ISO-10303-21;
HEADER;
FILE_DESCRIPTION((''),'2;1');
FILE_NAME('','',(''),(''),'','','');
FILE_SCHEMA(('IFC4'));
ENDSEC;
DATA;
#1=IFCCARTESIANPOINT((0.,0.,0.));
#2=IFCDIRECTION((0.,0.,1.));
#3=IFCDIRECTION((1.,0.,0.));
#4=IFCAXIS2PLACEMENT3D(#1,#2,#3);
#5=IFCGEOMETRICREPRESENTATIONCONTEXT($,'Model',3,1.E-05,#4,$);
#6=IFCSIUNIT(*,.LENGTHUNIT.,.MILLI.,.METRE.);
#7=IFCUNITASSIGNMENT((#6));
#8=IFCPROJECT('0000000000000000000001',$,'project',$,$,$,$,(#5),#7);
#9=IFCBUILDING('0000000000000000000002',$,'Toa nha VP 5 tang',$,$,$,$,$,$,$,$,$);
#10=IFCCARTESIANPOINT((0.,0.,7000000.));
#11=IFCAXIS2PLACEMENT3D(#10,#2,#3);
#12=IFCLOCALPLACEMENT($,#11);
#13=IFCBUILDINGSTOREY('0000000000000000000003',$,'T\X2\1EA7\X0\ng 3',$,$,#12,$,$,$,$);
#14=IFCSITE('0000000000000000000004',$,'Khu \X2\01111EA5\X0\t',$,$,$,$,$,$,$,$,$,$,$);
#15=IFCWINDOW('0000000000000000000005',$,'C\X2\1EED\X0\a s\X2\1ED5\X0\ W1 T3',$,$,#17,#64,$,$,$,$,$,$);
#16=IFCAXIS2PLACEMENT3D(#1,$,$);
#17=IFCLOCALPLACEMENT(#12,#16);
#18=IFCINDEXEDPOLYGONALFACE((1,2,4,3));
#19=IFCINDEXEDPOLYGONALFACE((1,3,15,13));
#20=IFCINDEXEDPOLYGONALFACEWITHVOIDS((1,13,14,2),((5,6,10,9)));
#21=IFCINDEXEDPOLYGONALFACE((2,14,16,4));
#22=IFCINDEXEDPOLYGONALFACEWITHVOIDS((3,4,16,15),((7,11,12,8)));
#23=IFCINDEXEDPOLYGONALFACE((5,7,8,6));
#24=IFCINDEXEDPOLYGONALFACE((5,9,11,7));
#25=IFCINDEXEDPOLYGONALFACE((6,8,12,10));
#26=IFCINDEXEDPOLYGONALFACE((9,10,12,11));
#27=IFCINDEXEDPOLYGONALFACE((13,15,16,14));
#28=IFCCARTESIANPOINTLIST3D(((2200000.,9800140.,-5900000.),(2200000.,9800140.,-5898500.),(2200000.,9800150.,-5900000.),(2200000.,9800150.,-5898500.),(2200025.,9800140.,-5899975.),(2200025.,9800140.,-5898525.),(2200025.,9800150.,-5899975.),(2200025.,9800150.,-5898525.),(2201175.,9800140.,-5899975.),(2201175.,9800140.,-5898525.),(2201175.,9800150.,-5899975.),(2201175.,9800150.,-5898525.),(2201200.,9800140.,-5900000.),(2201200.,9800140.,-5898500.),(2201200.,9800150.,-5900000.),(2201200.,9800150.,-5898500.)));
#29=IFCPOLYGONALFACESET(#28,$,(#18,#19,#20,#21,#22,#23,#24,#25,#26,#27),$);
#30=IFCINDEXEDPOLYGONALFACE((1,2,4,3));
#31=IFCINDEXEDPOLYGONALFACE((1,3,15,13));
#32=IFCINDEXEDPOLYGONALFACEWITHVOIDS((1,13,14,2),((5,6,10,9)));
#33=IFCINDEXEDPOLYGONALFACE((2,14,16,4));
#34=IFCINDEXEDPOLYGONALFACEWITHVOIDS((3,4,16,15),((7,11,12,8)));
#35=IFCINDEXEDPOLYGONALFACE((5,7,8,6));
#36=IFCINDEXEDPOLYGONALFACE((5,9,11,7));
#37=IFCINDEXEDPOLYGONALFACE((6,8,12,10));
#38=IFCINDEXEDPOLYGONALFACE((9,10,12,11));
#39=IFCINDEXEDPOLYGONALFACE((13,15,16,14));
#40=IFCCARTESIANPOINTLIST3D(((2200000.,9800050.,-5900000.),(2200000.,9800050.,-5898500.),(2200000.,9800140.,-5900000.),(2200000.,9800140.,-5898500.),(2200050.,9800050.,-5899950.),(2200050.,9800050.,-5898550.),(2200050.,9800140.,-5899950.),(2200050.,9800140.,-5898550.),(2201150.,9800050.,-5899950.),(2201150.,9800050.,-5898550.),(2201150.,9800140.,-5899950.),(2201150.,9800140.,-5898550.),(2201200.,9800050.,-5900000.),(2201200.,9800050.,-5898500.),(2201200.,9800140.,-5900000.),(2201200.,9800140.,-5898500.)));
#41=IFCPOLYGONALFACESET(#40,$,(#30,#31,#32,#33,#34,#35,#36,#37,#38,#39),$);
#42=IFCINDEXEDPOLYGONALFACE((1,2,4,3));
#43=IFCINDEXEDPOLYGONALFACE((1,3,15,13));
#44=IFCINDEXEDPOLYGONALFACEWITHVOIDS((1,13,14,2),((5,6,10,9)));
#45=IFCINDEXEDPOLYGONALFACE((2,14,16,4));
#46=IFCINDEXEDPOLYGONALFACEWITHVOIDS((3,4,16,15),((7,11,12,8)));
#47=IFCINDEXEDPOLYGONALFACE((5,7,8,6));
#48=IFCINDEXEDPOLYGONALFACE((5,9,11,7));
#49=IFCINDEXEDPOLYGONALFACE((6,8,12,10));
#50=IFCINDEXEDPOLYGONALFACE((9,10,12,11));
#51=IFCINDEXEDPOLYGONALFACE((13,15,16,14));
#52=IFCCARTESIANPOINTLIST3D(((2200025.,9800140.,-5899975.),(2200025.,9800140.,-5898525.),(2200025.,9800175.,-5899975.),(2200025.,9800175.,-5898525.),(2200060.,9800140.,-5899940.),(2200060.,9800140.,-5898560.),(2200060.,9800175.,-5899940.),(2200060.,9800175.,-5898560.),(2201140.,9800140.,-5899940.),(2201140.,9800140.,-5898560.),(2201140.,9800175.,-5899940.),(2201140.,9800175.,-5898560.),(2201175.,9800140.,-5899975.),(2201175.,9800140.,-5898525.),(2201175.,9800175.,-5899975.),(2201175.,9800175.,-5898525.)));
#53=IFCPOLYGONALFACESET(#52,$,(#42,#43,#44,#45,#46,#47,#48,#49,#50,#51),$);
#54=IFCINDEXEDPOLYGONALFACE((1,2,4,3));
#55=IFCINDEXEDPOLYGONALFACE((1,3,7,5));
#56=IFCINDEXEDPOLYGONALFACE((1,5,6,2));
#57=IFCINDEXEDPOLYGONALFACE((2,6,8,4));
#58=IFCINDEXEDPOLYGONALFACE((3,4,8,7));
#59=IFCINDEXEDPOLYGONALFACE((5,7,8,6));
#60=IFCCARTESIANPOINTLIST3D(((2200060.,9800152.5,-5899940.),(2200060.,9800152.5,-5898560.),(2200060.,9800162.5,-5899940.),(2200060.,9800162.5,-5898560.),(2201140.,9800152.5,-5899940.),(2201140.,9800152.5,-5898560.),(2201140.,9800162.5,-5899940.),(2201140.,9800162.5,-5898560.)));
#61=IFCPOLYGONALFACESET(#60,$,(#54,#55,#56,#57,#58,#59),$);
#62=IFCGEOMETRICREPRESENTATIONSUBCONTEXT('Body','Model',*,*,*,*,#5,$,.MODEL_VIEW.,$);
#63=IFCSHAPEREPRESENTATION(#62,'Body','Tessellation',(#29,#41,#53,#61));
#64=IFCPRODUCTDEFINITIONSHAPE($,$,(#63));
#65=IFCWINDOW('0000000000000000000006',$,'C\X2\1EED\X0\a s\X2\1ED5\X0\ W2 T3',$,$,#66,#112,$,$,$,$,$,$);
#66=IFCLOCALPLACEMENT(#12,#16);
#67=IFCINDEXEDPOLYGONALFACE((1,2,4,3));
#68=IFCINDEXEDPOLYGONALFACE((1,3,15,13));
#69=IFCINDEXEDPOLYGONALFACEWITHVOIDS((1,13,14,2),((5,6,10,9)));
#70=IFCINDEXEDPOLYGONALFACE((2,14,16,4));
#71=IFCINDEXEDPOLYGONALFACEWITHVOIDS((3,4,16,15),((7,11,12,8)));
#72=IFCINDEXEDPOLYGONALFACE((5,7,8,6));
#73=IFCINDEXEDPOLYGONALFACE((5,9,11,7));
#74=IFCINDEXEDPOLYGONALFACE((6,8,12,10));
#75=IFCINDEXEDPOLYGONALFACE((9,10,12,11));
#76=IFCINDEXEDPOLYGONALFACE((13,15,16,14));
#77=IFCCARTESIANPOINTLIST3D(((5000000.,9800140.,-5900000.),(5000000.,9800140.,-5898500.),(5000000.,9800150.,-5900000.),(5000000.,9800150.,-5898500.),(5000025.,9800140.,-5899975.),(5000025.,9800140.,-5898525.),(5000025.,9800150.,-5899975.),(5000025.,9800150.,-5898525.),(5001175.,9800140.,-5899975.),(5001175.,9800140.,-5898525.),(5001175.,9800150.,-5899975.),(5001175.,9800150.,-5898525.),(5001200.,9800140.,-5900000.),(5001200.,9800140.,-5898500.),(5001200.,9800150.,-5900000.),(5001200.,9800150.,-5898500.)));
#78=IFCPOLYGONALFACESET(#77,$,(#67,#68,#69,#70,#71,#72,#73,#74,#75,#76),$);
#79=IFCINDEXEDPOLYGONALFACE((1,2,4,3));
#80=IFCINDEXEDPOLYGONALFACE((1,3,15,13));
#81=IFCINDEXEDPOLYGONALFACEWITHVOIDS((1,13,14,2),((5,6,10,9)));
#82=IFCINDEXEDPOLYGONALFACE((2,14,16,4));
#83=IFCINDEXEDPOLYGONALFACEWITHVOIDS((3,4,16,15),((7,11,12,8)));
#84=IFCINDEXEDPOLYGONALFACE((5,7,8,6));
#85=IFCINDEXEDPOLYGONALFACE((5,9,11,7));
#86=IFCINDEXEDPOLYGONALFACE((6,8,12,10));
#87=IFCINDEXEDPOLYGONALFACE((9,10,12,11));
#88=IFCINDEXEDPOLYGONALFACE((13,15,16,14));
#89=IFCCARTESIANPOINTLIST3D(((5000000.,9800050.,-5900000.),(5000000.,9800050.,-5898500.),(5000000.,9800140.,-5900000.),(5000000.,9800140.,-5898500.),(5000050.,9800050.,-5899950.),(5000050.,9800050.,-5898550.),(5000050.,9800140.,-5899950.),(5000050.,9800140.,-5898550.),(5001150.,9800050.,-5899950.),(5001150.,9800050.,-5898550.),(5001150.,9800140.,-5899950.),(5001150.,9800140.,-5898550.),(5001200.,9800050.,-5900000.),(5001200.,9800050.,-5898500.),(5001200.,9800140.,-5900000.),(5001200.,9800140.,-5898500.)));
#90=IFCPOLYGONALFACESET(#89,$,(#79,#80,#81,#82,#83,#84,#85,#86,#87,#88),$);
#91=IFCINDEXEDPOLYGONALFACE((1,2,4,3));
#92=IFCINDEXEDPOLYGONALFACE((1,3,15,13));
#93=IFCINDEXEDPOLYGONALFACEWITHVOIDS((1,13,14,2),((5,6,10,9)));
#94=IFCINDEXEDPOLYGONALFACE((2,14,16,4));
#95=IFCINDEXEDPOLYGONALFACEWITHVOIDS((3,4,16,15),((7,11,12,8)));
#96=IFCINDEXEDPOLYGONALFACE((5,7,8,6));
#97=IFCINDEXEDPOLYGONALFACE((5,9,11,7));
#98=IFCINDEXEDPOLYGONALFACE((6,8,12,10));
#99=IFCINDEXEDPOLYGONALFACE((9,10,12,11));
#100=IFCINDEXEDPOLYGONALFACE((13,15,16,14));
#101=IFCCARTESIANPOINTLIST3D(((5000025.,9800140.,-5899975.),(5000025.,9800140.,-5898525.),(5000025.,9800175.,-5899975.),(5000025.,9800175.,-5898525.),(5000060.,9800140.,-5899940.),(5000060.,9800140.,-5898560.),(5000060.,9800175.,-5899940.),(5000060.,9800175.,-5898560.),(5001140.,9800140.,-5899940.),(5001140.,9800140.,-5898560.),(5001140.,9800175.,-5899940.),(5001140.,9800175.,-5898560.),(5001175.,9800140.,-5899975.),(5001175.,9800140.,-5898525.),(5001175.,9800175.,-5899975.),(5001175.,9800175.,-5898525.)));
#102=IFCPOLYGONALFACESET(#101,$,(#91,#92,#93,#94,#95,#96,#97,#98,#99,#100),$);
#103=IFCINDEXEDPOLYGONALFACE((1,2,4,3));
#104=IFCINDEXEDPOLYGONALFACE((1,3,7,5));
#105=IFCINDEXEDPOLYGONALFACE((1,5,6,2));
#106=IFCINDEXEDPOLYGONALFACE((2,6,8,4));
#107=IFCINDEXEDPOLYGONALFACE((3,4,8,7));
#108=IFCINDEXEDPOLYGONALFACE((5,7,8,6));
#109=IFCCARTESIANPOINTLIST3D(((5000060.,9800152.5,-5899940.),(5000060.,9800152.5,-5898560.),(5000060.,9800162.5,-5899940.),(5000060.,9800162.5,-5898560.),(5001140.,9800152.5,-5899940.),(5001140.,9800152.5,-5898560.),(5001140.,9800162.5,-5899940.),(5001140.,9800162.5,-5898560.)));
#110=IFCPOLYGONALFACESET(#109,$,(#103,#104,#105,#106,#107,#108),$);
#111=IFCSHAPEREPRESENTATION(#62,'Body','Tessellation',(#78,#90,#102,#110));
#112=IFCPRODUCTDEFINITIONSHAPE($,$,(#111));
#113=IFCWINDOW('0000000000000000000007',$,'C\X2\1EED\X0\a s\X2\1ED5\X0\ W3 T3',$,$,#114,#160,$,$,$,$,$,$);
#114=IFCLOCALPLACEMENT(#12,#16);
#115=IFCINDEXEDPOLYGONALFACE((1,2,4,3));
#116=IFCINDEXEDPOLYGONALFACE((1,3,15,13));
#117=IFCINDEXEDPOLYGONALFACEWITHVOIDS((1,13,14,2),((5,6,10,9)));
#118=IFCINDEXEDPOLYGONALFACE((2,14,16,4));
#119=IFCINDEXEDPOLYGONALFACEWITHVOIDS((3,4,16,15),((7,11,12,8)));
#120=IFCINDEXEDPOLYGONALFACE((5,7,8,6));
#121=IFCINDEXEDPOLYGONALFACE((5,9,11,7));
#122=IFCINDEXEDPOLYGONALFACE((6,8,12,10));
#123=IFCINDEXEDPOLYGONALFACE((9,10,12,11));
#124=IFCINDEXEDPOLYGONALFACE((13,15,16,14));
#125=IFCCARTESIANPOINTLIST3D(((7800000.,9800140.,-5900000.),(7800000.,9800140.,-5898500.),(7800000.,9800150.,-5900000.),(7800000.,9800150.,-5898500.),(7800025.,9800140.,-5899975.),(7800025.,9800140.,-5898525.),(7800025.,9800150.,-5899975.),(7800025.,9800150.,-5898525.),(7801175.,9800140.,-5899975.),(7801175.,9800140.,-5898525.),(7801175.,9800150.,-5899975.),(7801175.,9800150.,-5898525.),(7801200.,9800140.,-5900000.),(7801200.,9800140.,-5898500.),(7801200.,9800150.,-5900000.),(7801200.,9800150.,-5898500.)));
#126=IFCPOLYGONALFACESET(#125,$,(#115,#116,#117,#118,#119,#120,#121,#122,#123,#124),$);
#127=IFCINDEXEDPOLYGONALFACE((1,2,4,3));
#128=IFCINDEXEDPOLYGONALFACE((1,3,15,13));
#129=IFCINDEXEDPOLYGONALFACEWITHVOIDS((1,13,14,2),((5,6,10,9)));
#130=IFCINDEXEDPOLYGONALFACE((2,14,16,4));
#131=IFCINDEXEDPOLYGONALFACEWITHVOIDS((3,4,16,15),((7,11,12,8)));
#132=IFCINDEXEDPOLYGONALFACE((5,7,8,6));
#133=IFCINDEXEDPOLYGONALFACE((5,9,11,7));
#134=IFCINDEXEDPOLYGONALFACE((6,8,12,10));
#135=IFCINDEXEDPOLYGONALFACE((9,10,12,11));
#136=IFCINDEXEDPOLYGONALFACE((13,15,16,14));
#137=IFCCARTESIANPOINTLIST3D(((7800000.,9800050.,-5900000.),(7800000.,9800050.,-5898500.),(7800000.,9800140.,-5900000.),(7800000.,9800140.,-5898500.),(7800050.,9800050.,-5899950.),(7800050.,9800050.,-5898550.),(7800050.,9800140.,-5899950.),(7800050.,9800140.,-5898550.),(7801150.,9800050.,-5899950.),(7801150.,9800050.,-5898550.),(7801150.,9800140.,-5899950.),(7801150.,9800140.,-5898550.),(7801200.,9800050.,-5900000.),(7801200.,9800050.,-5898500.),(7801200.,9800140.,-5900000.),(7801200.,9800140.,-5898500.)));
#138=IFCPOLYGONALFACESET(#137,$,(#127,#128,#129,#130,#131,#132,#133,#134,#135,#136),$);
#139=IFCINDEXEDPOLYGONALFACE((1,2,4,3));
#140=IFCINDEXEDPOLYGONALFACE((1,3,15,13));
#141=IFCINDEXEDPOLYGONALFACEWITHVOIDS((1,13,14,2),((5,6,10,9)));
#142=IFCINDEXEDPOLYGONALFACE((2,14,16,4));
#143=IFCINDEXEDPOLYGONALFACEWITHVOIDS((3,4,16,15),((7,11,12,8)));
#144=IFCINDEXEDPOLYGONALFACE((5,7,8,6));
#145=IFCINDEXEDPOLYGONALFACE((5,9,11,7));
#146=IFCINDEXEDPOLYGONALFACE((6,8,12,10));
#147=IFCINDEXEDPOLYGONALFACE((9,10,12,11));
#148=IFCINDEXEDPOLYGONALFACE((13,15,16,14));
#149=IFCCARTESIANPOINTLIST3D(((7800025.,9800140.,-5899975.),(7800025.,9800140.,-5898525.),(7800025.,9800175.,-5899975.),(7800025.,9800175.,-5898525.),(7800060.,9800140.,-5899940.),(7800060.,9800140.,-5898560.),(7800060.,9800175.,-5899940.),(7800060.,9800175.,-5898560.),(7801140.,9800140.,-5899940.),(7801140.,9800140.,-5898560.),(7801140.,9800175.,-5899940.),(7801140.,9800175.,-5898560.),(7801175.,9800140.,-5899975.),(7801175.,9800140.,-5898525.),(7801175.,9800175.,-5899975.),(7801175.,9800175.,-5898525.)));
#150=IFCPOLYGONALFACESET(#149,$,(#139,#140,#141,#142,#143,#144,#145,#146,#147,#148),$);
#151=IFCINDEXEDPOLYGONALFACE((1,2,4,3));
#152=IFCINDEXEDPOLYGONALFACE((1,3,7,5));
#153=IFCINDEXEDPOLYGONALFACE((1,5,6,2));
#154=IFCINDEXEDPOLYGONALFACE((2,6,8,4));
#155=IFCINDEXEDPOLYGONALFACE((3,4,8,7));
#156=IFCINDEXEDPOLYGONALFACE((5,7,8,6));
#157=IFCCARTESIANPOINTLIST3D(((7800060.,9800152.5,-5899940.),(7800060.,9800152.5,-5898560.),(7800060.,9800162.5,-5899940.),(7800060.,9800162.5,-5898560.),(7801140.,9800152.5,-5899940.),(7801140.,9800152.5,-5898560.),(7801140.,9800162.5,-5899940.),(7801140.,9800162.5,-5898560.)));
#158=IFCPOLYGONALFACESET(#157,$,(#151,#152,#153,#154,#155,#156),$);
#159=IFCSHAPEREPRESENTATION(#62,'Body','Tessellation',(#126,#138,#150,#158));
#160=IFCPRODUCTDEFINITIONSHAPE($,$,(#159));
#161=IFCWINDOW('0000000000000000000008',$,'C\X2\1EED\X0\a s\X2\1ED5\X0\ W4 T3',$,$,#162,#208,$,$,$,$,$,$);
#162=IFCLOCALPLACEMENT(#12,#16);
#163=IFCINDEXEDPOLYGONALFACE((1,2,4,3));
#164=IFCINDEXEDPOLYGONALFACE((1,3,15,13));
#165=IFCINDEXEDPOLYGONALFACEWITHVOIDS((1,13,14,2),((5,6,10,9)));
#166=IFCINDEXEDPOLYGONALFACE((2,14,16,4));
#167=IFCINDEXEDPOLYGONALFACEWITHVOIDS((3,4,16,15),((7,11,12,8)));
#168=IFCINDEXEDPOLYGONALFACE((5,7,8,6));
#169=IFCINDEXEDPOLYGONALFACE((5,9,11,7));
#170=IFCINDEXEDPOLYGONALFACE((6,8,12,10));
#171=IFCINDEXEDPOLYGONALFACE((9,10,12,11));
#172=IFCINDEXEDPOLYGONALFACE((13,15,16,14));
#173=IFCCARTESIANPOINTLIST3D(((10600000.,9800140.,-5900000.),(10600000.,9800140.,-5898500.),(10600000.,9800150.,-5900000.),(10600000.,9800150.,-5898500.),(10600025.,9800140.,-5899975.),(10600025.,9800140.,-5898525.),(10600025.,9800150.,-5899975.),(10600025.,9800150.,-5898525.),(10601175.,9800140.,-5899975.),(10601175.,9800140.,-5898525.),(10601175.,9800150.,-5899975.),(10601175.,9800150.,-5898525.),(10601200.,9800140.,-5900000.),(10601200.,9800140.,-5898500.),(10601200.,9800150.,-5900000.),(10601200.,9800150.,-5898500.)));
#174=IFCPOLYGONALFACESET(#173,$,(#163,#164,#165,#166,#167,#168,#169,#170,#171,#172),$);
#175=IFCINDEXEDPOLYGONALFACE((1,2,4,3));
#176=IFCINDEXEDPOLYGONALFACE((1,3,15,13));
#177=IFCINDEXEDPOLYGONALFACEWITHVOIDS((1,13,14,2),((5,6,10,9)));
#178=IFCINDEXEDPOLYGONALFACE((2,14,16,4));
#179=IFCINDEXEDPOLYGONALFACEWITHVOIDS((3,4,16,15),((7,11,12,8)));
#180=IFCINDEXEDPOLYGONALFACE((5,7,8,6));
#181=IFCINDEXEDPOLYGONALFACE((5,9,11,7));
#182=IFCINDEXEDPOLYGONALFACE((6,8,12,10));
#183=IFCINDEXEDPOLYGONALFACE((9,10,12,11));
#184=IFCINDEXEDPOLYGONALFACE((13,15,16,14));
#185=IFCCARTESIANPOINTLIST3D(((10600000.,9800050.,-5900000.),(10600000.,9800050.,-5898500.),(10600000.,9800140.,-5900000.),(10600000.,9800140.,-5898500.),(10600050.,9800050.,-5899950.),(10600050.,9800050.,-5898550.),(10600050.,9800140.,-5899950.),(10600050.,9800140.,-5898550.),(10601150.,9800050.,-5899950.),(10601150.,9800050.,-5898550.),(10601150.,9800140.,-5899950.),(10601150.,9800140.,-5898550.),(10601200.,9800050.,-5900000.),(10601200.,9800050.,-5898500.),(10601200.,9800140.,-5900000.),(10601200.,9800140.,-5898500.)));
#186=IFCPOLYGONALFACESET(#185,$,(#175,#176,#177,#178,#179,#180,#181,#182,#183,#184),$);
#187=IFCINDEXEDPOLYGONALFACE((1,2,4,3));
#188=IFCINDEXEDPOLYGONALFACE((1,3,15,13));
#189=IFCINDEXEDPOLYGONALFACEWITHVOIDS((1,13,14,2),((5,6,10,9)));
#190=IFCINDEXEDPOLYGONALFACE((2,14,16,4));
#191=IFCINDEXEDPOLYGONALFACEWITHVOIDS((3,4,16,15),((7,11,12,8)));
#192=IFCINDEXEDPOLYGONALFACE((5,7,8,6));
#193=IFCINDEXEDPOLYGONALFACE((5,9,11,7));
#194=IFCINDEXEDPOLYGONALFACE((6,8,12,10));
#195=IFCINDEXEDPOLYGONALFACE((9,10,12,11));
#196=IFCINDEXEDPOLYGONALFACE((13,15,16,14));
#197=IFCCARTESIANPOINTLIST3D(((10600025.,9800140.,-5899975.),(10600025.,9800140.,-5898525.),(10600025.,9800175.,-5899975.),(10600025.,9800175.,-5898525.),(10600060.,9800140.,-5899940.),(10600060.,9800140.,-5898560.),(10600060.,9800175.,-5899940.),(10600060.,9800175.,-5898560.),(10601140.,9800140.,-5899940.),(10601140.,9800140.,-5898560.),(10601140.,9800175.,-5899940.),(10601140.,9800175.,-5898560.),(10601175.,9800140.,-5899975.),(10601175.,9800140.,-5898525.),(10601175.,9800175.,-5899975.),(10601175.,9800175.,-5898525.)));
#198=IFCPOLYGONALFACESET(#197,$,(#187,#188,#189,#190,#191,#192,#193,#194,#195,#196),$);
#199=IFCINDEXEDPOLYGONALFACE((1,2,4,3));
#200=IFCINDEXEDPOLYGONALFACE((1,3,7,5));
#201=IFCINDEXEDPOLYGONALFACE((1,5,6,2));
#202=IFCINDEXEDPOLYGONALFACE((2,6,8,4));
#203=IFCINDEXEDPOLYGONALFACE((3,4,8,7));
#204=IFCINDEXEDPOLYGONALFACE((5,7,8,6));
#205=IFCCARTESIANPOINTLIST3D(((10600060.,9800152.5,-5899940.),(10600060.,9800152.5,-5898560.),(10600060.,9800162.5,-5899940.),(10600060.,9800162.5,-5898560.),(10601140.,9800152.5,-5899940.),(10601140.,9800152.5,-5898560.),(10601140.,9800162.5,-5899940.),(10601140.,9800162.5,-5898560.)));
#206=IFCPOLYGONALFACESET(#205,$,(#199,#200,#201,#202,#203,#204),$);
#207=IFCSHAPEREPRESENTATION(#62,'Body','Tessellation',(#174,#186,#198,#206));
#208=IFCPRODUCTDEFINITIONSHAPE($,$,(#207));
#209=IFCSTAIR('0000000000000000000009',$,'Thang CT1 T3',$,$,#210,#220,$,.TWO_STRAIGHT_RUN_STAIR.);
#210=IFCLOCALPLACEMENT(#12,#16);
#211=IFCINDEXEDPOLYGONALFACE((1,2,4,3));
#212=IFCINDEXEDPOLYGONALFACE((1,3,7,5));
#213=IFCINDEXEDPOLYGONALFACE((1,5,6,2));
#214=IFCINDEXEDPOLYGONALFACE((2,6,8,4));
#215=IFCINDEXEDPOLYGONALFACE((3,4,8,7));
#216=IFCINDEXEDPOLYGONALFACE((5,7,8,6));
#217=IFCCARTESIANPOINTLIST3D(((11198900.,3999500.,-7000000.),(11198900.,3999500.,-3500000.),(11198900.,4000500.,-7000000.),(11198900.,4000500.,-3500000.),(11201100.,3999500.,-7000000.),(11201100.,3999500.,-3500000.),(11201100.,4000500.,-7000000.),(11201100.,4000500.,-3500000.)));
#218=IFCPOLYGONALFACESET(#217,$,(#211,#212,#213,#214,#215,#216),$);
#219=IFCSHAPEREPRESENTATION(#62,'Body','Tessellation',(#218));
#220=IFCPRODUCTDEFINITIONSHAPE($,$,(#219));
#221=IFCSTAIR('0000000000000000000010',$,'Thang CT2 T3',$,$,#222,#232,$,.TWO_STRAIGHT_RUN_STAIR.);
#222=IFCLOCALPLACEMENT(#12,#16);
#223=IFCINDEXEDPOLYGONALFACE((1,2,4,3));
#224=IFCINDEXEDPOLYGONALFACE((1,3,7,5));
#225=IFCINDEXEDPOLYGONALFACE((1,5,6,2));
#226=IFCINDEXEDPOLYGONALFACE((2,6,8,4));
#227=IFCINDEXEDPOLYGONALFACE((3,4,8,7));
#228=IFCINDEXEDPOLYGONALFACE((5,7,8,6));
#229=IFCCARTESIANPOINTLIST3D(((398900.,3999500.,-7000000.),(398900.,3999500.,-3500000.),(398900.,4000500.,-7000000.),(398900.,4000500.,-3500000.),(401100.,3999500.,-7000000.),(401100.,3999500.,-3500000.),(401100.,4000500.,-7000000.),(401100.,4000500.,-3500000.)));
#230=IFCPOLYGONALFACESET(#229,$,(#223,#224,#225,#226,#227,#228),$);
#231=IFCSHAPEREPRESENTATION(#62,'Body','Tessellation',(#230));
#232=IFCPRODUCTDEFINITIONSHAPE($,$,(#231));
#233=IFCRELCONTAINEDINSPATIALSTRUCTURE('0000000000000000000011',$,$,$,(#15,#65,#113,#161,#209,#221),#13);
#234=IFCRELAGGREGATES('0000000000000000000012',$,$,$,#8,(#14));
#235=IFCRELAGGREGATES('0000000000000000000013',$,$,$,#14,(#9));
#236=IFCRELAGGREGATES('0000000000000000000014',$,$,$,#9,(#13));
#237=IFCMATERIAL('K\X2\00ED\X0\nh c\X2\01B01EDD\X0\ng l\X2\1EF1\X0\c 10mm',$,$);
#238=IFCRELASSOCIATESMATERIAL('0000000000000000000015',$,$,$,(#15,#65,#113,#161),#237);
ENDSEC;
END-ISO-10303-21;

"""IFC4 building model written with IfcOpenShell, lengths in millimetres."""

from ifc_helpers import new_model, entity, si_unit, frame, origin_with_axes, place, context, subcontext, project, spatial, line, indexed_curve, outline, extrude, material, element, save


model = new_model("IFC4")

# Units and contexts
model_context = context("Model", 3, precision=1e-05, world=origin_with_axes())
body_context = subcontext(model_context, "Body", "Model", "MODEL_VIEW")
ifc_project = project(units=[si_unit("LENGTHUNIT", "METRE", prefix="MILLI")], contexts=[model_context])

# Site, building, storey
site = spatial("IfcSite", under=ifc_project, Name="Khu đất")
building = spatial("IfcBuilding", under=site, Name="Toa nha VP 5 tang")
storey_placement = place(None, frame((0.0, 0.0, 7000000.0), z_axis=(0.0, 0.0, 1.0), x_axis=(1.0, 0.0, 0.0)))
storey = spatial("IfcBuildingStorey", under=building, at=storey_placement, Name="Tầng 3")

# Windows
ifc_material_1 = material(Name="Kính cường lực 10mm")
for number, where, z_axis, x_axis, name in (
    (1, (2200000.0, 9800000.0, -5900000.0), (0.0, 0.0, 1.0), (1.0, 0.0, 0.0), "Cửa sổ W1 T3"),
    (2, (5000000.0, 9800000.0, -5900000.0), (0.0, 0.0, 1.0), (1.0, 0.0, 0.0), "Cửa sổ W2 T3"),
    (3, (7800000.0, 9800000.0, -5900000.0), (0.0, 0.0, 1.0), (1.0, 0.0, 0.0), "Cửa sổ W3 T3"),
    (4, (10600000.0, 9800000.0, -5900000.0), (0.0, 0.0, 1.0), (1.0, 0.0, 0.0), "Cửa sổ W4 T3"),
):
    element("IfcWindow", number, at=place(storey_placement, frame(where, z_axis=z_axis, x_axis=x_axis)), inside=storey, material=ifc_material_1, Name=name, context=body_context, shape_type="SolidModel", body=[
        extrude(outline(indexed_curve([(0.0, 0.0), (1200.0, 0.0), (1200.0, 1500.0), (0.0, 1500.0)], segments=[line(1, 2, 3, 4, 1)]), holes=[indexed_curve([(25.0, 25.0), (1175.0, 25.0), (1175.0, 1475.0), (25.0, 1475.0)], segments=[line(1, 2, 3, 4, 1)])]), frame((0.0, 140.0, 0.0), z_axis=(0.0, -1.0, 0.0), x_axis=(1.0, 0.0, 0.0)), (0.0, 0.0, -1.0), 10.0),
        extrude(outline(indexed_curve([(0.0, 0.0), (1200.0, 0.0), (1200.0, 1500.0), (0.0, 1500.0)], segments=[line(1, 2, 3, 4, 1)]), holes=[indexed_curve([(50.0, 50.0), (1150.0, 50.0), (1150.0, 1450.0), (50.0, 1450.0)], segments=[line(1, 2, 3, 4, 1)])]), frame((0.0, 50.0, 0.0), z_axis=(0.0, -1.0, 0.0), x_axis=(1.0, 0.0, 0.0)), (0.0, 0.0, -1.0), 90.0),
        extrude(outline(indexed_curve([(0.0, 0.0), (1150.0, 0.0), (1150.0, 1450.0), (0.0, 1450.0)], segments=[line(1, 2, 3, 4, 1)]), holes=[indexed_curve([(35.0, 35.0), (1115.0, 35.0), (1115.0, 1415.0), (35.0, 1415.0)], segments=[line(1, 2, 3, 4, 1)])]), frame((25.0, 140.0, 25.0), z_axis=(0.0, -1.0, 0.0), x_axis=(1.0, 0.0, 0.0)), (0.0, 0.0, -1.0), 35.0),
        extrude(outline(indexed_curve([(35.0, 35.0), (1115.0, 35.0), (1115.0, 1415.0), (35.0, 1415.0)], segments=[line(1, 2, 3, 4, 1)])), frame((25.0, 152.5, 25.0), z_axis=(0.0, -1.0, 0.0), x_axis=(1.0, 0.0, 0.0)), (0.0, 0.0, -1.0), 10.0),
    ])

# Stairs
for number, where, z_axis, x_axis, name in (
    (5, (11200000.0, 4000000.0, -7000000.0), (0.0, 0.0, 1.0), (1.0, 0.0, 0.0), "Thang CT1 T3"),
    (6, (400000.0, 4000000.0, -7000000.0), (0.0, 0.0, 1.0), (1.0, 0.0, 0.0), "Thang CT2 T3"),
):
    element("IfcStair", number, at=place(storey_placement, frame(where, z_axis=z_axis, x_axis=x_axis)), inside=storey, Name=name, PredefinedType="TWO_STRAIGHT_RUN_STAIR", context=body_context, shape_type="SweptSolid", body=[
        extrude(entity("IfcRectangleProfileDef", None, None, None, 2200.0, 1000.0), origin_with_axes(), (0.0, 0.0, 1.0), 3500000.0),
    ])

save(model, "model.ifc")
